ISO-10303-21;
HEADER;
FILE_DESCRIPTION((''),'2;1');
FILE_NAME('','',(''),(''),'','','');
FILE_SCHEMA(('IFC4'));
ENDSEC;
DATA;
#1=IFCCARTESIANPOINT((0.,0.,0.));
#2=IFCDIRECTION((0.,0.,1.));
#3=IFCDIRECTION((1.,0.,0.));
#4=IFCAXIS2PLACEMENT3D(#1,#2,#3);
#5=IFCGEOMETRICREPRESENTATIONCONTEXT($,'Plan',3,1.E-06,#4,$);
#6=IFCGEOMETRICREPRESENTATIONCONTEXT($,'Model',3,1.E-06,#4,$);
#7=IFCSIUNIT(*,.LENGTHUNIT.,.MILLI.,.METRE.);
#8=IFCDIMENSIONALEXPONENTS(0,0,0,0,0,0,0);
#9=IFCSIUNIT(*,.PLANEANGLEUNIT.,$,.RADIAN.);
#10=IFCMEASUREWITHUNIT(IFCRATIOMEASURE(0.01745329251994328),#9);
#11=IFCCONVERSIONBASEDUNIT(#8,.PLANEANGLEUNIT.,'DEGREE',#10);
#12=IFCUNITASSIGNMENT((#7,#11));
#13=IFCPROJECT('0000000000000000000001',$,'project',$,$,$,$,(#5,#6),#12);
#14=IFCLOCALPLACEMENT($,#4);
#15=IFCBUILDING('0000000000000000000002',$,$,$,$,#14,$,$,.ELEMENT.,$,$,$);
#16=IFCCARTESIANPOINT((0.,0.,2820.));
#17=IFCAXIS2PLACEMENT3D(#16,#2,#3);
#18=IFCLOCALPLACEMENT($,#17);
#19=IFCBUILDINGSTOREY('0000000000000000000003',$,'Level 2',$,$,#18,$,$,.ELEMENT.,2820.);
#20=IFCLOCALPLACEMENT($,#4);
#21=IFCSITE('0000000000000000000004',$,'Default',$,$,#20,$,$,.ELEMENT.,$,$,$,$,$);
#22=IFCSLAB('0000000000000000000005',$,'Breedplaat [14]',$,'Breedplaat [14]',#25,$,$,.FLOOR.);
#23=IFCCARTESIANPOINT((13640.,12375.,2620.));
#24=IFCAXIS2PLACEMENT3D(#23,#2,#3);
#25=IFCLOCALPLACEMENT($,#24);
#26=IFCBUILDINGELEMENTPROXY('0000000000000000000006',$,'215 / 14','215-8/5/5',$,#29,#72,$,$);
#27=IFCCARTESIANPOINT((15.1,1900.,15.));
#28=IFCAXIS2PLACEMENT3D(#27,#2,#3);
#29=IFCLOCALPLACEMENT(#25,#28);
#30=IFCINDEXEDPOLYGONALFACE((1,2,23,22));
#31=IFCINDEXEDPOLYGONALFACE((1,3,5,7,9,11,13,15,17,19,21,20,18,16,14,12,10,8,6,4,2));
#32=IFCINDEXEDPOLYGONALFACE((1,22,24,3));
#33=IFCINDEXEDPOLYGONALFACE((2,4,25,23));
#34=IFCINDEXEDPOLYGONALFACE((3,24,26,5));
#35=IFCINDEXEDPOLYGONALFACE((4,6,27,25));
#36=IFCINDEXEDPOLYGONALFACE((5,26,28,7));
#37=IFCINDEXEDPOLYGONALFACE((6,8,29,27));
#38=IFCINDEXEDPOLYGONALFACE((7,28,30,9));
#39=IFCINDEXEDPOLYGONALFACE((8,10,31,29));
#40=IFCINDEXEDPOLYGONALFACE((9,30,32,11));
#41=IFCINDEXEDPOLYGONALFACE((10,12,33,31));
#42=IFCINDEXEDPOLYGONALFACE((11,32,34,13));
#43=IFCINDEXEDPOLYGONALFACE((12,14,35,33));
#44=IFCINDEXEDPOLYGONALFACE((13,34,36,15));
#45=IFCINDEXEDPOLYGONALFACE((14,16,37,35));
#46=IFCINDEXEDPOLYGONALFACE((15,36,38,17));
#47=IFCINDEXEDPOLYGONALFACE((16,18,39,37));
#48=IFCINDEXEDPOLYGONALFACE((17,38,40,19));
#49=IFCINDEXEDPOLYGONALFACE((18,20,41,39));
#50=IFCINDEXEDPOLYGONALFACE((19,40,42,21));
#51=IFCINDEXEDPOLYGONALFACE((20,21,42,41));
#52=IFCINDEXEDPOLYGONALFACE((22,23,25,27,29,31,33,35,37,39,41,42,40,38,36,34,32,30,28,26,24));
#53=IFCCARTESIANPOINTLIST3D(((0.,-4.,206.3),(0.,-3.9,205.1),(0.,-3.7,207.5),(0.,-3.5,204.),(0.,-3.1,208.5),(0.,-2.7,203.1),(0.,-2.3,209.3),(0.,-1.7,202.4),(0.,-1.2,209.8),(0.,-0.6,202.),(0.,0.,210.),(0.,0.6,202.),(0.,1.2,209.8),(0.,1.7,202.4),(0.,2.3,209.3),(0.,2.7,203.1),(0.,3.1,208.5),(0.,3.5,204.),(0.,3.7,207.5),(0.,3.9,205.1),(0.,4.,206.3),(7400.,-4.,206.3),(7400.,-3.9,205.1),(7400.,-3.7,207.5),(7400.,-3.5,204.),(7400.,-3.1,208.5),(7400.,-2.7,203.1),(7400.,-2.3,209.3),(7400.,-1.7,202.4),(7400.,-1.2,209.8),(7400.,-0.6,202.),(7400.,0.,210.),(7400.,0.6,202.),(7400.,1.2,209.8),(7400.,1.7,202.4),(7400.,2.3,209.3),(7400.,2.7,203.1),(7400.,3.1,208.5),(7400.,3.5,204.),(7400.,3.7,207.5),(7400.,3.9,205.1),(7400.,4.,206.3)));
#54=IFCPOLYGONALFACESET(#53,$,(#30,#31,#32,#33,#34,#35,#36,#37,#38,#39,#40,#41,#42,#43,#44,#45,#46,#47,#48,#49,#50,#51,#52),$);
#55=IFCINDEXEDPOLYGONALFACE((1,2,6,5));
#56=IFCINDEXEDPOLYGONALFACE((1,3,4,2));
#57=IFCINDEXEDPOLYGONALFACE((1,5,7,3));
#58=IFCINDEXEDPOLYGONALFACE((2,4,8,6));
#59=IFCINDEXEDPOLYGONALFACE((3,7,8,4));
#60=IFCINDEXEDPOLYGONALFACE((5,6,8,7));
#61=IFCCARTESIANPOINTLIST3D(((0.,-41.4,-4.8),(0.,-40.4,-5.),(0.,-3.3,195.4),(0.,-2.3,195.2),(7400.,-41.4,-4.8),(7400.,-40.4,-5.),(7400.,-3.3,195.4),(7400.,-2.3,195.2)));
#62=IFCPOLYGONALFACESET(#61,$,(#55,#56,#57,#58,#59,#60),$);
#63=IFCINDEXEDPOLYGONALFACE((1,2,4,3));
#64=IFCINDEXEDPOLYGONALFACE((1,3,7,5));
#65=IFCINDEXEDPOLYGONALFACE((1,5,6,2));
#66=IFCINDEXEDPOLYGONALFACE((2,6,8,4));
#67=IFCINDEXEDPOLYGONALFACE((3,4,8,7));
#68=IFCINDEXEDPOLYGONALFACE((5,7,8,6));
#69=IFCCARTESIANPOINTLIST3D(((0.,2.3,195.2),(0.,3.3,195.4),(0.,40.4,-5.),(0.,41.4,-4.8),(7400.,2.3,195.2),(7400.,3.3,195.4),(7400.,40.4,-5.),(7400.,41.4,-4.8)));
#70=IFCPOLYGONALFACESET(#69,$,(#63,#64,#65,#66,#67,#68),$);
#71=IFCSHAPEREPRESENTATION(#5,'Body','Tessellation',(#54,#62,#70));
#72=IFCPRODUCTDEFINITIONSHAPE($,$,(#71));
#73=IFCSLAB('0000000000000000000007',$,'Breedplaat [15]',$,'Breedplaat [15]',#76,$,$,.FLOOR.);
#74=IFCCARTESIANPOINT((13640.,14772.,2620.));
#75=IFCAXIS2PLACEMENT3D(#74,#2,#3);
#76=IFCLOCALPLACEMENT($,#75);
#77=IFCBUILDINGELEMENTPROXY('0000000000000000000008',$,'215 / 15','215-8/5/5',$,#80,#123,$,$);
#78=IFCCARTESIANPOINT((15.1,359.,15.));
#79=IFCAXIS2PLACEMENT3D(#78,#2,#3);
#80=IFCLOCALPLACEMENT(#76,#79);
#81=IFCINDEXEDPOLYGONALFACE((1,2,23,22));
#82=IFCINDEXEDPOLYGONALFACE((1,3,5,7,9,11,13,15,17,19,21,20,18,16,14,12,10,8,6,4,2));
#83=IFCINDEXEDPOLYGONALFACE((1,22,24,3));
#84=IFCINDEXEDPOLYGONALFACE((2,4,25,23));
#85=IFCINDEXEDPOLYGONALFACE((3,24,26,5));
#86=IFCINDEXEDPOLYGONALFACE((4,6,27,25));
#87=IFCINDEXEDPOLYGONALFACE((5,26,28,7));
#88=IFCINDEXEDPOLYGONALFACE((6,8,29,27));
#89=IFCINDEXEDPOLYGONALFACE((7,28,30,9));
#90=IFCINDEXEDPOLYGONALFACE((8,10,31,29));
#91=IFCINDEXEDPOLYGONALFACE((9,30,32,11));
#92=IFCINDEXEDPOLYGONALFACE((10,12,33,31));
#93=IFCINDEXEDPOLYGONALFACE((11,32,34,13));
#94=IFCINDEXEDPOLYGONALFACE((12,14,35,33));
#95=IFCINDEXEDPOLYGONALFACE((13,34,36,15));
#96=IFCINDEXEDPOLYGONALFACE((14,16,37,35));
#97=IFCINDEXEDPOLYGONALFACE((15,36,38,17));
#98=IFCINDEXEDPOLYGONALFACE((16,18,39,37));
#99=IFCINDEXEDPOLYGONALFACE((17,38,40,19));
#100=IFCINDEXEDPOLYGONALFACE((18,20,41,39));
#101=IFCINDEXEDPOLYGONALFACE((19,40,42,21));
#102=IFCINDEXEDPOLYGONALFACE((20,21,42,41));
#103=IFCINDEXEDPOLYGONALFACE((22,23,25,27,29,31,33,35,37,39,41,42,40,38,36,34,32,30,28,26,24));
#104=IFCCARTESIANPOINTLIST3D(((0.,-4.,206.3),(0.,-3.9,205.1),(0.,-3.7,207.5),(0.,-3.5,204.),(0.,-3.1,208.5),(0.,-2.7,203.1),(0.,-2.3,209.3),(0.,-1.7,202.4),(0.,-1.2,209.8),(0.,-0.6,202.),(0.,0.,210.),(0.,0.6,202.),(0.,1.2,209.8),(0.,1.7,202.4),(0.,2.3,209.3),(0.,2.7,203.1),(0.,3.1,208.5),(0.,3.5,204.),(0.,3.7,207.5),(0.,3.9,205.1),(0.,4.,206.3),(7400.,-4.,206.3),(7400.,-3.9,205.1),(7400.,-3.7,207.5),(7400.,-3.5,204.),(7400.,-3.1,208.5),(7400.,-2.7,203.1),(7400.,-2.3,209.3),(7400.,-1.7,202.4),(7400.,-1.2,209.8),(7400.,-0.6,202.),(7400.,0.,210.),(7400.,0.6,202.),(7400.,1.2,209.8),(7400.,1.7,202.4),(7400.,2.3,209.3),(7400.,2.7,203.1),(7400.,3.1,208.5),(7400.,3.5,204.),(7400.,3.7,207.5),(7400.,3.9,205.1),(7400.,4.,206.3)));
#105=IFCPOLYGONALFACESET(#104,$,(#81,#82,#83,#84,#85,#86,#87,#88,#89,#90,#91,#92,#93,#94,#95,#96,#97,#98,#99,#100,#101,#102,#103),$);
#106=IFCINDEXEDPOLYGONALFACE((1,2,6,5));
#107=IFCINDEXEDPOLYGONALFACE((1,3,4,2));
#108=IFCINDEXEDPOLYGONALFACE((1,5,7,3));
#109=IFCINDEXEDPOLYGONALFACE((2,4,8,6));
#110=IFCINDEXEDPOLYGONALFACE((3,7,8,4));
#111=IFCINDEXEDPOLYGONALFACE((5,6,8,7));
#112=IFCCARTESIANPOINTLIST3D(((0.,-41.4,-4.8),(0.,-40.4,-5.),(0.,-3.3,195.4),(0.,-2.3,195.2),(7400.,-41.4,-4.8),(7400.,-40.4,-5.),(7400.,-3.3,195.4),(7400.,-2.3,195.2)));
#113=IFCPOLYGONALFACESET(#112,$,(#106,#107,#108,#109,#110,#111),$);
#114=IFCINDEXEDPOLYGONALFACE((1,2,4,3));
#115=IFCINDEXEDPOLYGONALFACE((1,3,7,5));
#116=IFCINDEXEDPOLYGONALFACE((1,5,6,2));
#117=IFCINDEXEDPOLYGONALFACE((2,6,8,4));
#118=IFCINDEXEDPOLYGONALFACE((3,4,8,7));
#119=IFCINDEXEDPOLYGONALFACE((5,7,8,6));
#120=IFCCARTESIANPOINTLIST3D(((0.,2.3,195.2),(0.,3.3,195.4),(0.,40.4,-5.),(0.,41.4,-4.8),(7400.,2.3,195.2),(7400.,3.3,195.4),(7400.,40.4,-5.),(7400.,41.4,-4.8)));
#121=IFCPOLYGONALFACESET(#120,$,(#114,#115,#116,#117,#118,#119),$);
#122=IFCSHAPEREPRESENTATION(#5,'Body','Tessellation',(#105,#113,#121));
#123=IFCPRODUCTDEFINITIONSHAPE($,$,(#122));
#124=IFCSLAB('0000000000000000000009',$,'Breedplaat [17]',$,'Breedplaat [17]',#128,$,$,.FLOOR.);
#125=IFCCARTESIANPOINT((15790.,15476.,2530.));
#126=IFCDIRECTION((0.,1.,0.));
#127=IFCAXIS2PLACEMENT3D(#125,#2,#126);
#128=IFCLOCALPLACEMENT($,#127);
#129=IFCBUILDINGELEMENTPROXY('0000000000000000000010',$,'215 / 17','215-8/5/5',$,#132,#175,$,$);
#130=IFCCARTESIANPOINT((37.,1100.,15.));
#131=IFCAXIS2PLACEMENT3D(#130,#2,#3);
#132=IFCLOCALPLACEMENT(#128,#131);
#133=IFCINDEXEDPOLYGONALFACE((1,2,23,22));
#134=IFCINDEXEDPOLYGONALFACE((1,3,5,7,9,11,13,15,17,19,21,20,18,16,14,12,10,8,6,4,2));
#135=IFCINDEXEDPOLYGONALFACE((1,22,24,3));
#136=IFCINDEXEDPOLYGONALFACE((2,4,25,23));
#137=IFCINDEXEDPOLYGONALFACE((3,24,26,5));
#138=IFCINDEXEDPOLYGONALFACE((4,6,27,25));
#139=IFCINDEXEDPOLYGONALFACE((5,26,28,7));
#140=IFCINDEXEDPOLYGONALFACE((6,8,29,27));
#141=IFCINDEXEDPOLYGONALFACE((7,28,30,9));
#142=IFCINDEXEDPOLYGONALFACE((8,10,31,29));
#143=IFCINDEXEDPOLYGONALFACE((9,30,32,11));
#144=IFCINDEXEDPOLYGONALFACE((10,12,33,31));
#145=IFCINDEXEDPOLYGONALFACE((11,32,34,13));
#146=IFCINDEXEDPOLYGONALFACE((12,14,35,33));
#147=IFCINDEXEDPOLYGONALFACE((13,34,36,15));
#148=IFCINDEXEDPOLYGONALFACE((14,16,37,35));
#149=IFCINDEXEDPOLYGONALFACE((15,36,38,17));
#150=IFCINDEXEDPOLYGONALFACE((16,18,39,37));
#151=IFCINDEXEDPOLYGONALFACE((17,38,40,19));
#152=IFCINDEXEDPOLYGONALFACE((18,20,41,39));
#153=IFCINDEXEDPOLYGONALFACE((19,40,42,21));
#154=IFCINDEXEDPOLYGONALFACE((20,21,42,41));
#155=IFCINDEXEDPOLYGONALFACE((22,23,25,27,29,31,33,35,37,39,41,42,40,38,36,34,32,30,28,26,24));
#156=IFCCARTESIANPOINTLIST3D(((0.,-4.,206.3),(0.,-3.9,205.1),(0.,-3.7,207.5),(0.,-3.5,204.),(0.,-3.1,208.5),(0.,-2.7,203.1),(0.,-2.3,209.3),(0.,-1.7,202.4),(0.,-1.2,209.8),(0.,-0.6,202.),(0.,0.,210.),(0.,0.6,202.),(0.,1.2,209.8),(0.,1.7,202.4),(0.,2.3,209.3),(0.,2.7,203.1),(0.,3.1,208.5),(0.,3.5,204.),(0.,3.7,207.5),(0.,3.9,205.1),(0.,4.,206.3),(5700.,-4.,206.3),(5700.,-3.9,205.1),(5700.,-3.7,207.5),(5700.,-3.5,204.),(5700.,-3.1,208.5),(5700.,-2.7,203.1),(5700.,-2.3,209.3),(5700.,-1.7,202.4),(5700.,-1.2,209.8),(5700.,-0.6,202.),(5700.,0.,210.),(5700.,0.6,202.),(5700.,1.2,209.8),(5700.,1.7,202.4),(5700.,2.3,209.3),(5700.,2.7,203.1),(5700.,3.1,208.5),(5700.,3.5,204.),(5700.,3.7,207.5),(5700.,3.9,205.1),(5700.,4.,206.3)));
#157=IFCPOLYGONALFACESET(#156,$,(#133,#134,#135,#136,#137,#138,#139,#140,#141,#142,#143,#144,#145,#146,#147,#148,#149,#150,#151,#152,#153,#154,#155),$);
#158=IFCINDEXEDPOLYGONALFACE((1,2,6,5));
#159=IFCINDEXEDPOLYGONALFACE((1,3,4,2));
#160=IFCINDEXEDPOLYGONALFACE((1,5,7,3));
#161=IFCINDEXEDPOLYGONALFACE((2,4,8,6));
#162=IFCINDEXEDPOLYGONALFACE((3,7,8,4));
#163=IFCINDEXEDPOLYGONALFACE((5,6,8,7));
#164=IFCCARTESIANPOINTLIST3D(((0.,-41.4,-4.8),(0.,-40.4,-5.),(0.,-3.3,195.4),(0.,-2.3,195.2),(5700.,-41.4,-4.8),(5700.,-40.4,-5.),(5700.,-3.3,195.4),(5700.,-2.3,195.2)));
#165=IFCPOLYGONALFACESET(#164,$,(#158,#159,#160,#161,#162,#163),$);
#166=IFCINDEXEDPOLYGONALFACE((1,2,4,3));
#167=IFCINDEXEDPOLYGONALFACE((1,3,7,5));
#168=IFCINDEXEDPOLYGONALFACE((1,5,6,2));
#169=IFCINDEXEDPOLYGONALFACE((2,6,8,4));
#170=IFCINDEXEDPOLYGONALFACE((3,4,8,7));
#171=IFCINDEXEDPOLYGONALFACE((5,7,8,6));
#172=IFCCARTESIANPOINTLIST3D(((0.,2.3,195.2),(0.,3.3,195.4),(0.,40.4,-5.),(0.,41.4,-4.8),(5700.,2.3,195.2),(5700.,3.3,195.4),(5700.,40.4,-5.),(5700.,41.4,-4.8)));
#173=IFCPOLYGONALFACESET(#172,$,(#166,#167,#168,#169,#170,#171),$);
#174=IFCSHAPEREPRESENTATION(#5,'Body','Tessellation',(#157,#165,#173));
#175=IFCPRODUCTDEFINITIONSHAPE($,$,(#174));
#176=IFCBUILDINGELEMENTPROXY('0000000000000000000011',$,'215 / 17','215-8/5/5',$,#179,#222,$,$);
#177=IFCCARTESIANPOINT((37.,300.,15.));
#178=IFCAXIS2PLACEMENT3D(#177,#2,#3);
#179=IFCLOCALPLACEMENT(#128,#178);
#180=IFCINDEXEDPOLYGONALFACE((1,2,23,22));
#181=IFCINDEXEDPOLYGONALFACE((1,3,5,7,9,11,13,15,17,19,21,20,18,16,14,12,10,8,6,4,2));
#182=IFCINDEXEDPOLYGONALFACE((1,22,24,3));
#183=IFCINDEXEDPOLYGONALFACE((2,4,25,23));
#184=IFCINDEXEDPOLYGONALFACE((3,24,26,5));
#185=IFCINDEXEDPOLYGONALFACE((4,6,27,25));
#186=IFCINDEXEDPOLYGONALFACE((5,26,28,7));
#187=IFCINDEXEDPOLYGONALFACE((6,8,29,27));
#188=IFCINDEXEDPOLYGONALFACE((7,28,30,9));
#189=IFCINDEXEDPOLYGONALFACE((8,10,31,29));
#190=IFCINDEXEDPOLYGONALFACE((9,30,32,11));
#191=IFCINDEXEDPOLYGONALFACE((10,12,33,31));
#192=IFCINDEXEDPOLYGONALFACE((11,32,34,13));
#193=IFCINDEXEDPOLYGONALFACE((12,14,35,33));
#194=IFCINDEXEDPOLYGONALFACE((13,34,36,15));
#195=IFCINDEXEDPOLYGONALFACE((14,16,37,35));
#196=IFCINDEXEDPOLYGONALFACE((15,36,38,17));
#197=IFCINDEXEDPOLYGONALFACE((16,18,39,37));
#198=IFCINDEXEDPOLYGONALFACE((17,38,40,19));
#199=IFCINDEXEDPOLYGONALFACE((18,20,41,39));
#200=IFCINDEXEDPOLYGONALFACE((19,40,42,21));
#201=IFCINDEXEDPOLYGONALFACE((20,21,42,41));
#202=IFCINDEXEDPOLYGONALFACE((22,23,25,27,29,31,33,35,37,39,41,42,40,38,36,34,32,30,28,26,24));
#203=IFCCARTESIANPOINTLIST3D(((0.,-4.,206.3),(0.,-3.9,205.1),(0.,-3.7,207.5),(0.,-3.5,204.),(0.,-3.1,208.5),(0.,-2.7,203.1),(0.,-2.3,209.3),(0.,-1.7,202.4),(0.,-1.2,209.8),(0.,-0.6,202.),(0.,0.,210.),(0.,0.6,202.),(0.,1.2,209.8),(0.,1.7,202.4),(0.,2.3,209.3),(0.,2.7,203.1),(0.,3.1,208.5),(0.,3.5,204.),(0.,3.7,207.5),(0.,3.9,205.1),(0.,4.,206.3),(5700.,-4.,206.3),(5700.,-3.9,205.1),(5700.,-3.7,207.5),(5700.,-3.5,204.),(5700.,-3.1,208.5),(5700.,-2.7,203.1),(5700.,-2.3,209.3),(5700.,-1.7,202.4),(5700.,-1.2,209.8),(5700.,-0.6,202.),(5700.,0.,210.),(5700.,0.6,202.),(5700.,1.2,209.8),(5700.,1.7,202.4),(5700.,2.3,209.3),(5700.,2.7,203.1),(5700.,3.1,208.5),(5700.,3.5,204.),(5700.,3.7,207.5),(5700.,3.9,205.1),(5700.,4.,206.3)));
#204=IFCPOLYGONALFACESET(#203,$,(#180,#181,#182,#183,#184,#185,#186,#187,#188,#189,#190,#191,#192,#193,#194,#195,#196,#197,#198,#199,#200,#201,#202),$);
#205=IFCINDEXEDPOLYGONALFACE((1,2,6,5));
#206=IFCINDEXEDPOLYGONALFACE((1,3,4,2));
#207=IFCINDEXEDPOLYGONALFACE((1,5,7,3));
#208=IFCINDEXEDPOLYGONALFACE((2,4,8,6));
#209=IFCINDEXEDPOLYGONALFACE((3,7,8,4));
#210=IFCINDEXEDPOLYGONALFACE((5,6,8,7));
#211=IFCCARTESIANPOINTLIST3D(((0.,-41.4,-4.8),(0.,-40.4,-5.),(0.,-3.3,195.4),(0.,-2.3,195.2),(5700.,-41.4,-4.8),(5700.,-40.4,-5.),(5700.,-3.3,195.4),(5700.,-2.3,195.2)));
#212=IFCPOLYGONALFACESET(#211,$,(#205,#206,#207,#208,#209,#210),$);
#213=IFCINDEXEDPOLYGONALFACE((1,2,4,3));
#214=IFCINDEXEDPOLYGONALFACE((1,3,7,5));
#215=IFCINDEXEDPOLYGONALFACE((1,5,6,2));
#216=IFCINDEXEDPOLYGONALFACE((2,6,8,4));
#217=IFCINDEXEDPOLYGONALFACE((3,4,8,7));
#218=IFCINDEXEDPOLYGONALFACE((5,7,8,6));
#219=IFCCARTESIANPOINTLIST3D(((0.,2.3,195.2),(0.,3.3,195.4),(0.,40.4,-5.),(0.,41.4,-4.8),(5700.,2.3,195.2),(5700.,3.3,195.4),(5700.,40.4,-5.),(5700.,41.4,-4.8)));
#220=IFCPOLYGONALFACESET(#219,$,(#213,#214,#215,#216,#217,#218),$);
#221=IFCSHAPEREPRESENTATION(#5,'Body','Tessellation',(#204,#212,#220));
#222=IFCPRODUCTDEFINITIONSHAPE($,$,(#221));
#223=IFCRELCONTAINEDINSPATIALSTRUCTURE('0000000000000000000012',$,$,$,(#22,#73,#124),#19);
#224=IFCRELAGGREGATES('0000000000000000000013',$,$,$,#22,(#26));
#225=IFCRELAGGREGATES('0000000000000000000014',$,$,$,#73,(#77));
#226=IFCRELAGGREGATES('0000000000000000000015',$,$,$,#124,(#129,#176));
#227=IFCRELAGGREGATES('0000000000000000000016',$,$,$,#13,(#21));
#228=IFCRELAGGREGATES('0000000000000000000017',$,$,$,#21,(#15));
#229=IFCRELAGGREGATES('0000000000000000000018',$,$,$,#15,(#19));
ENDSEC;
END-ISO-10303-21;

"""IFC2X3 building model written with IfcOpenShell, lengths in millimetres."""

from ifc_helpers import new_model, entity, si_unit, converted_unit, frame, origin_with_axes, origin_2d_with_axis, place, context, project, spatial, rectangle, circle, extrude, element, aggregate, save


model = new_model("IFC2X3")

# Units and contexts
plan_context = context("Plan", 3, precision=1e-06, world=origin_with_axes())
model_context = context("Model", 3, precision=1e-06, world=origin_with_axes())
ifc_project = project(units=[si_unit("LENGTHUNIT", "METRE", prefix="MILLI"), converted_unit("PLANEANGLEUNIT", "DEGREE", entity("IfcRatioMeasure", 0.01745329251994328), si_unit("PLANEANGLEUNIT", "RADIAN"), dimensions=[0, 0, 0, 0, 0, 0, 0])], contexts=[plan_context, model_context])

# Site, building, storey
site_placement = place(None, origin_with_axes())
site = spatial("IfcSite", under=ifc_project, at=site_placement, Name="Default", CompositionType="ELEMENT")
building_placement = place(None, origin_with_axes())
building = spatial("IfcBuilding", under=site, at=building_placement, CompositionType="ELEMENT")
storey_placement = place(None, frame((0.0, 0.0, 2820.0), z_axis=(0.0, 0.0, 1.0), x_axis=(1.0, 0.0, 0.0)))
storey = spatial("IfcBuildingStorey", under=building, at=storey_placement, Name="Level 2", CompositionType="ELEMENT", Elevation=2820.0)

# Slabs, building element proxies
slab_1_placement = place(None, frame((13640.0, 12375.0, 2620.0), z_axis=(0.0, 0.0, 1.0), x_axis=(1.0, 0.0, 0.0)))
slab_1 = element("IfcSlab", 1, at=slab_1_placement, inside=storey, Name="Breedplaat [14]", ObjectType="Breedplaat [14]", PredefinedType="FLOOR")
proxy_1_placement = place(slab_1_placement, frame((15.1, 1900.0, 15.0), z_axis=(0.0, 0.0, 1.0), x_axis=(1.0, 0.0, 0.0)))
proxy_1 = element("IfcBuildingElementProxy", 2, at=proxy_1_placement, Name="215 / 14", Description="215-8/5/5", context=plan_context, shape_type="SweptSolid", body=[
    extrude(circle(Radius=4.0, at=origin_2d_with_axis()), frame((0.0, 0.0, 206.0), z_axis=(1.0, 0.0, 0.0), x_axis=(0.0, 0.0, 1.0)), (0.0, 0.0, 1.0), 7400.0),
    extrude(rectangle(XDim=203.8, YDim=1.0, at=origin_2d_with_axis()), frame((0.0, -21.9, 95.2), z_axis=(1.0, 0.0, 0.0), x_axis=(0.0, 0.187112, 0.982339)), (0.0, 0.0, 1.0), 7400.0),
    extrude(rectangle(XDim=203.8, YDim=1.0, at=origin_2d_with_axis()), frame((0.0, 21.9, 95.2), z_axis=(1.0, 0.0, 0.0), x_axis=(0.0, -0.187112, 0.982339)), (0.0, 0.0, 1.0), 7400.0),
])
aggregate(slab_1, [proxy_1])
slab_2_placement = place(None, frame((13640.0, 14772.0, 2620.0), z_axis=(0.0, 0.0, 1.0), x_axis=(1.0, 0.0, 0.0)))
slab_2 = element("IfcSlab", 3, at=slab_2_placement, inside=storey, Name="Breedplaat [15]", ObjectType="Breedplaat [15]", PredefinedType="FLOOR")
proxy_2_placement = place(slab_2_placement, frame((15.1, 359.0, 15.0), z_axis=(0.0, 0.0, 1.0), x_axis=(1.0, 0.0, 0.0)))
proxy_2 = element("IfcBuildingElementProxy", 4, at=proxy_2_placement, Name="215 / 15", Description="215-8/5/5", context=plan_context, shape_type="SweptSolid", body=[
    extrude(circle(Radius=4.0, at=origin_2d_with_axis()), frame((0.0, 0.0, 206.0), z_axis=(1.0, 0.0, 0.0), x_axis=(0.0, 0.0, 1.0)), (0.0, 0.0, 1.0), 7400.0),
    extrude(rectangle(XDim=203.8, YDim=1.0, at=origin_2d_with_axis()), frame((0.0, -21.9, 95.2), z_axis=(1.0, 0.0, 0.0), x_axis=(0.0, 0.187112, 0.982339)), (0.0, 0.0, 1.0), 7400.0),
    extrude(rectangle(XDim=203.8, YDim=1.0, at=origin_2d_with_axis()), frame((0.0, 21.9, 95.2), z_axis=(1.0, 0.0, 0.0), x_axis=(0.0, -0.187112, 0.982339)), (0.0, 0.0, 1.0), 7400.0),
])
aggregate(slab_2, [proxy_2])

# Slab, building element proxies
slab_3_placement = place(None, frame((15790.0, 15476.0, 2530.0), z_axis=(0.0, 0.0, 1.0), x_axis=(0.0, 1.0, 0.0)))
slab_3 = element("IfcSlab", 5, at=slab_3_placement, inside=storey, Name="Breedplaat [17]", ObjectType="Breedplaat [17]", PredefinedType="FLOOR")
proxy_3_placement = place(slab_3_placement, frame((37.0, 1100.0, 15.0), z_axis=(0.0, 0.0, 1.0), x_axis=(1.0, 0.0, 0.0)))
proxy_3 = element("IfcBuildingElementProxy", 6, at=proxy_3_placement, Name="215 / 17", Description="215-8/5/5", context=plan_context, shape_type="SweptSolid", body=[
    extrude(circle(Radius=4.0, at=origin_2d_with_axis()), frame((0.0, 0.0, 206.0), z_axis=(1.0, 0.0, 0.0), x_axis=(0.0, 0.0, 1.0)), (0.0, 0.0, 1.0), 5700.0),
    extrude(rectangle(XDim=203.8, YDim=1.0, at=origin_2d_with_axis()), frame((0.0, -21.9, 95.2), z_axis=(1.0, 0.0, 0.0), x_axis=(0.0, 0.187112, 0.982339)), (0.0, 0.0, 1.0), 5700.0),
    extrude(rectangle(XDim=203.8, YDim=1.0, at=origin_2d_with_axis()), frame((0.0, 21.9, 95.2), z_axis=(1.0, 0.0, 0.0), x_axis=(0.0, -0.187112, 0.982339)), (0.0, 0.0, 1.0), 5700.0),
])
proxy_4_placement = place(slab_3_placement, frame((37.0, 300.0, 15.0), z_axis=(0.0, 0.0, 1.0), x_axis=(1.0, 0.0, 0.0)))
proxy_4 = element("IfcBuildingElementProxy", 7, at=proxy_4_placement, Name="215 / 17", Description="215-8/5/5", context=plan_context, shape_type="SweptSolid", body=[
    extrude(circle(Radius=4.0, at=origin_2d_with_axis()), frame((0.0, 0.0, 206.0), z_axis=(1.0, 0.0, 0.0), x_axis=(0.0, 0.0, 1.0)), (0.0, 0.0, 1.0), 5700.0),
    extrude(rectangle(XDim=203.8, YDim=1.0, at=origin_2d_with_axis()), frame((0.0, -21.9, 95.2), z_axis=(1.0, 0.0, 0.0), x_axis=(0.0, 0.187112, 0.982339)), (0.0, 0.0, 1.0), 5700.0),
    extrude(rectangle(XDim=203.8, YDim=1.0, at=origin_2d_with_axis()), frame((0.0, 21.9, 95.2), z_axis=(1.0, 0.0, 0.0), x_axis=(0.0, -0.187112, 0.982339)), (0.0, 0.0, 1.0), 5700.0),
])
aggregate(slab_3, [proxy_3, proxy_4])

save(model, "model.ifc")
